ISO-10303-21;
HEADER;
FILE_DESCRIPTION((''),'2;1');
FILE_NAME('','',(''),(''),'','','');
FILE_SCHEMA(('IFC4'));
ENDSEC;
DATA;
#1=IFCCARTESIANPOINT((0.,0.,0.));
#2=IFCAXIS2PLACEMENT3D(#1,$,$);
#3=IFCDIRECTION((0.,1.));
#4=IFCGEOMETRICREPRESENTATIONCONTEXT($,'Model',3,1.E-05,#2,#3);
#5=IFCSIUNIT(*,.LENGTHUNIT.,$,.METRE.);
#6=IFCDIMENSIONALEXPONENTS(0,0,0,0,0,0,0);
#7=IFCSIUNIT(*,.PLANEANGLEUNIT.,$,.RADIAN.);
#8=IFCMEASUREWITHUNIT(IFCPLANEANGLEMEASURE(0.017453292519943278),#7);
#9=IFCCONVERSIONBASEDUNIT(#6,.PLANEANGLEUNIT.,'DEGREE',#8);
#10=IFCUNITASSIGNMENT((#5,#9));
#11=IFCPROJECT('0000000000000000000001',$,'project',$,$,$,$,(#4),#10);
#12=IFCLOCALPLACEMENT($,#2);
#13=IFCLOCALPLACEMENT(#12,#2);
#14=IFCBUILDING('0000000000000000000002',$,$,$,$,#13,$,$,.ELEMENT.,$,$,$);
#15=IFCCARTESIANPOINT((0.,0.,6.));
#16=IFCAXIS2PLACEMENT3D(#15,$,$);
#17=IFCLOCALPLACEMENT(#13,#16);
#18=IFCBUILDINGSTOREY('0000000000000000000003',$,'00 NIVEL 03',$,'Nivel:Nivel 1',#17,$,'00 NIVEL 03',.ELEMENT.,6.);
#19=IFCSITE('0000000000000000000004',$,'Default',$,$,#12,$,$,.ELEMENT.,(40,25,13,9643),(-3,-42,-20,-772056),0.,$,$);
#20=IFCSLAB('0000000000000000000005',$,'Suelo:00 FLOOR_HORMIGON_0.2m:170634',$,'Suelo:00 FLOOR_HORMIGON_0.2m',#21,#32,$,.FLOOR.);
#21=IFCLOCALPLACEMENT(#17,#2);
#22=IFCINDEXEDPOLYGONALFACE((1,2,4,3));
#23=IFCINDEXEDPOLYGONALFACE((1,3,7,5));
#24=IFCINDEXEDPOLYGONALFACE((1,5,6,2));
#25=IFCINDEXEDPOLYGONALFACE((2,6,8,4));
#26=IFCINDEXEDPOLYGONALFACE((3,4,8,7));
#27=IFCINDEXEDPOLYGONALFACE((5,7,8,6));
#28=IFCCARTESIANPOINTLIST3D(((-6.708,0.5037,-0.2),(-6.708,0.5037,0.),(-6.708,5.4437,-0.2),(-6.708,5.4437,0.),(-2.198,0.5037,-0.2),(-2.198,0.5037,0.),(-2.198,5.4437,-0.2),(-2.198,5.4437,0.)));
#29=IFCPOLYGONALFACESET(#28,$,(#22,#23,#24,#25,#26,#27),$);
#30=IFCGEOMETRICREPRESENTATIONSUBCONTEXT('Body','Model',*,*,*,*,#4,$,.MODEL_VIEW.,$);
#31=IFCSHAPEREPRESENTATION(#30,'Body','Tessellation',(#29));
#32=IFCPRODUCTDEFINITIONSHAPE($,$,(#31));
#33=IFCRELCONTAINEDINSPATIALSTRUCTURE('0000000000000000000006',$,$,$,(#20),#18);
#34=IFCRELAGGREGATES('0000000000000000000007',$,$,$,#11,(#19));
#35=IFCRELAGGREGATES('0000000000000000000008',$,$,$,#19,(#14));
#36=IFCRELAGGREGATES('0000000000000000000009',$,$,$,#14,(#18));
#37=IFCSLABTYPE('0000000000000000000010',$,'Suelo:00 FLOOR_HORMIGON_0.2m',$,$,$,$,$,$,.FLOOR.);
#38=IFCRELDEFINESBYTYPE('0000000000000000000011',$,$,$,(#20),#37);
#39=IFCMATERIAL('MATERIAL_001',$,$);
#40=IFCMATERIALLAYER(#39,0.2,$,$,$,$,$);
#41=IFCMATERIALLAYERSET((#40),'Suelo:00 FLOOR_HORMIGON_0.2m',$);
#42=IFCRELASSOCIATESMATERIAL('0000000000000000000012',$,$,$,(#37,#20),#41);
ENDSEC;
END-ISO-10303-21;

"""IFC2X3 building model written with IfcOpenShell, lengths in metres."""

from ifc_helpers import new_model, entity, si_unit, converted_unit, direction, frame, frame_2d, origin, place, context, subcontext, project, spatial, rectangle, extrude, material, layer, layer_set, layer_usage, type_object, element, save


model = new_model("IFC2X3")

# Units and contexts
model_context = context("Model", 3, precision=1e-05, world=origin(), true_north=direction((0.0, 1.0)))
body_context = subcontext(model_context, "Body", "Model", "MODEL_VIEW")
ifc_project = project(units=[si_unit("LENGTHUNIT", "METRE"), converted_unit("PLANEANGLEUNIT", "DEGREE", entity("IfcPlaneAngleMeasure", 0.017453292519943278), si_unit("PLANEANGLEUNIT", "RADIAN"), dimensions=[0, 0, 0, 0, 0, 0, 0])], contexts=[model_context])

# Site, building, storey
site_placement = place(None, origin())
site = spatial("IfcSite", under=ifc_project, at=site_placement, Name="Default", CompositionType="ELEMENT", RefLatitude=(40, 25, 13, 9643), RefLongitude=(-3, -42, -20, -772056), RefElevation=0.0)
building_placement = place(site_placement, origin())
building = spatial("IfcBuilding", under=site, at=building_placement, CompositionType="ELEMENT")
storey_placement = place(building_placement, frame((0.0, 0.0, 6.0)))
storey = spatial("IfcBuildingStorey", under=building, at=storey_placement, Name="00 NIVEL 03", ObjectType="Nivel:Nivel 1", LongName="00 NIVEL 03", CompositionType="ELEMENT", Elevation=6.0)

# Slab
ifc_material = material(Name="MATERIAL_001")
ifc_layer = layer(ifc_material, 0.2)
ifc_layer_set = layer_set([ifc_layer], Name="Suelo:00 FLOOR_HORMIGON_0.2m")
ifc_layer_usage = layer_usage(ifc_layer_set, "AXIS3", "POSITIVE", 0.0)
slab_type = type_object("IfcSlabType", Name="Suelo:00 FLOOR_HORMIGON_0.2m", PredefinedType="FLOOR", material=ifc_layer_set)
slab_placement = place(storey_placement, origin())
element("IfcSlab", 1, at=slab_placement, inside=storey, type_object=slab_type, material=ifc_layer_usage, Name="Suelo:00 FLOOR_HORMIGON_0.2m:170634", ObjectType="Suelo:00 FLOOR_HORMIGON_0.2m", PredefinedType="FLOOR", context=body_context, shape_type="SweptSolid", body=[
    extrude(rectangle(XDim=4.94, YDim=4.51, at=frame_2d((0.0, 0.0), x_axis=(1.0, 0.0))), frame((-4.453, 2.9737, 0.0), z_axis=(0.0, 0.0, -1.0), x_axis=(0.0, 1.0, 0.0)), (0.0, 0.0, 1.0), 0.2),
])

save(model, "model.ifc")
